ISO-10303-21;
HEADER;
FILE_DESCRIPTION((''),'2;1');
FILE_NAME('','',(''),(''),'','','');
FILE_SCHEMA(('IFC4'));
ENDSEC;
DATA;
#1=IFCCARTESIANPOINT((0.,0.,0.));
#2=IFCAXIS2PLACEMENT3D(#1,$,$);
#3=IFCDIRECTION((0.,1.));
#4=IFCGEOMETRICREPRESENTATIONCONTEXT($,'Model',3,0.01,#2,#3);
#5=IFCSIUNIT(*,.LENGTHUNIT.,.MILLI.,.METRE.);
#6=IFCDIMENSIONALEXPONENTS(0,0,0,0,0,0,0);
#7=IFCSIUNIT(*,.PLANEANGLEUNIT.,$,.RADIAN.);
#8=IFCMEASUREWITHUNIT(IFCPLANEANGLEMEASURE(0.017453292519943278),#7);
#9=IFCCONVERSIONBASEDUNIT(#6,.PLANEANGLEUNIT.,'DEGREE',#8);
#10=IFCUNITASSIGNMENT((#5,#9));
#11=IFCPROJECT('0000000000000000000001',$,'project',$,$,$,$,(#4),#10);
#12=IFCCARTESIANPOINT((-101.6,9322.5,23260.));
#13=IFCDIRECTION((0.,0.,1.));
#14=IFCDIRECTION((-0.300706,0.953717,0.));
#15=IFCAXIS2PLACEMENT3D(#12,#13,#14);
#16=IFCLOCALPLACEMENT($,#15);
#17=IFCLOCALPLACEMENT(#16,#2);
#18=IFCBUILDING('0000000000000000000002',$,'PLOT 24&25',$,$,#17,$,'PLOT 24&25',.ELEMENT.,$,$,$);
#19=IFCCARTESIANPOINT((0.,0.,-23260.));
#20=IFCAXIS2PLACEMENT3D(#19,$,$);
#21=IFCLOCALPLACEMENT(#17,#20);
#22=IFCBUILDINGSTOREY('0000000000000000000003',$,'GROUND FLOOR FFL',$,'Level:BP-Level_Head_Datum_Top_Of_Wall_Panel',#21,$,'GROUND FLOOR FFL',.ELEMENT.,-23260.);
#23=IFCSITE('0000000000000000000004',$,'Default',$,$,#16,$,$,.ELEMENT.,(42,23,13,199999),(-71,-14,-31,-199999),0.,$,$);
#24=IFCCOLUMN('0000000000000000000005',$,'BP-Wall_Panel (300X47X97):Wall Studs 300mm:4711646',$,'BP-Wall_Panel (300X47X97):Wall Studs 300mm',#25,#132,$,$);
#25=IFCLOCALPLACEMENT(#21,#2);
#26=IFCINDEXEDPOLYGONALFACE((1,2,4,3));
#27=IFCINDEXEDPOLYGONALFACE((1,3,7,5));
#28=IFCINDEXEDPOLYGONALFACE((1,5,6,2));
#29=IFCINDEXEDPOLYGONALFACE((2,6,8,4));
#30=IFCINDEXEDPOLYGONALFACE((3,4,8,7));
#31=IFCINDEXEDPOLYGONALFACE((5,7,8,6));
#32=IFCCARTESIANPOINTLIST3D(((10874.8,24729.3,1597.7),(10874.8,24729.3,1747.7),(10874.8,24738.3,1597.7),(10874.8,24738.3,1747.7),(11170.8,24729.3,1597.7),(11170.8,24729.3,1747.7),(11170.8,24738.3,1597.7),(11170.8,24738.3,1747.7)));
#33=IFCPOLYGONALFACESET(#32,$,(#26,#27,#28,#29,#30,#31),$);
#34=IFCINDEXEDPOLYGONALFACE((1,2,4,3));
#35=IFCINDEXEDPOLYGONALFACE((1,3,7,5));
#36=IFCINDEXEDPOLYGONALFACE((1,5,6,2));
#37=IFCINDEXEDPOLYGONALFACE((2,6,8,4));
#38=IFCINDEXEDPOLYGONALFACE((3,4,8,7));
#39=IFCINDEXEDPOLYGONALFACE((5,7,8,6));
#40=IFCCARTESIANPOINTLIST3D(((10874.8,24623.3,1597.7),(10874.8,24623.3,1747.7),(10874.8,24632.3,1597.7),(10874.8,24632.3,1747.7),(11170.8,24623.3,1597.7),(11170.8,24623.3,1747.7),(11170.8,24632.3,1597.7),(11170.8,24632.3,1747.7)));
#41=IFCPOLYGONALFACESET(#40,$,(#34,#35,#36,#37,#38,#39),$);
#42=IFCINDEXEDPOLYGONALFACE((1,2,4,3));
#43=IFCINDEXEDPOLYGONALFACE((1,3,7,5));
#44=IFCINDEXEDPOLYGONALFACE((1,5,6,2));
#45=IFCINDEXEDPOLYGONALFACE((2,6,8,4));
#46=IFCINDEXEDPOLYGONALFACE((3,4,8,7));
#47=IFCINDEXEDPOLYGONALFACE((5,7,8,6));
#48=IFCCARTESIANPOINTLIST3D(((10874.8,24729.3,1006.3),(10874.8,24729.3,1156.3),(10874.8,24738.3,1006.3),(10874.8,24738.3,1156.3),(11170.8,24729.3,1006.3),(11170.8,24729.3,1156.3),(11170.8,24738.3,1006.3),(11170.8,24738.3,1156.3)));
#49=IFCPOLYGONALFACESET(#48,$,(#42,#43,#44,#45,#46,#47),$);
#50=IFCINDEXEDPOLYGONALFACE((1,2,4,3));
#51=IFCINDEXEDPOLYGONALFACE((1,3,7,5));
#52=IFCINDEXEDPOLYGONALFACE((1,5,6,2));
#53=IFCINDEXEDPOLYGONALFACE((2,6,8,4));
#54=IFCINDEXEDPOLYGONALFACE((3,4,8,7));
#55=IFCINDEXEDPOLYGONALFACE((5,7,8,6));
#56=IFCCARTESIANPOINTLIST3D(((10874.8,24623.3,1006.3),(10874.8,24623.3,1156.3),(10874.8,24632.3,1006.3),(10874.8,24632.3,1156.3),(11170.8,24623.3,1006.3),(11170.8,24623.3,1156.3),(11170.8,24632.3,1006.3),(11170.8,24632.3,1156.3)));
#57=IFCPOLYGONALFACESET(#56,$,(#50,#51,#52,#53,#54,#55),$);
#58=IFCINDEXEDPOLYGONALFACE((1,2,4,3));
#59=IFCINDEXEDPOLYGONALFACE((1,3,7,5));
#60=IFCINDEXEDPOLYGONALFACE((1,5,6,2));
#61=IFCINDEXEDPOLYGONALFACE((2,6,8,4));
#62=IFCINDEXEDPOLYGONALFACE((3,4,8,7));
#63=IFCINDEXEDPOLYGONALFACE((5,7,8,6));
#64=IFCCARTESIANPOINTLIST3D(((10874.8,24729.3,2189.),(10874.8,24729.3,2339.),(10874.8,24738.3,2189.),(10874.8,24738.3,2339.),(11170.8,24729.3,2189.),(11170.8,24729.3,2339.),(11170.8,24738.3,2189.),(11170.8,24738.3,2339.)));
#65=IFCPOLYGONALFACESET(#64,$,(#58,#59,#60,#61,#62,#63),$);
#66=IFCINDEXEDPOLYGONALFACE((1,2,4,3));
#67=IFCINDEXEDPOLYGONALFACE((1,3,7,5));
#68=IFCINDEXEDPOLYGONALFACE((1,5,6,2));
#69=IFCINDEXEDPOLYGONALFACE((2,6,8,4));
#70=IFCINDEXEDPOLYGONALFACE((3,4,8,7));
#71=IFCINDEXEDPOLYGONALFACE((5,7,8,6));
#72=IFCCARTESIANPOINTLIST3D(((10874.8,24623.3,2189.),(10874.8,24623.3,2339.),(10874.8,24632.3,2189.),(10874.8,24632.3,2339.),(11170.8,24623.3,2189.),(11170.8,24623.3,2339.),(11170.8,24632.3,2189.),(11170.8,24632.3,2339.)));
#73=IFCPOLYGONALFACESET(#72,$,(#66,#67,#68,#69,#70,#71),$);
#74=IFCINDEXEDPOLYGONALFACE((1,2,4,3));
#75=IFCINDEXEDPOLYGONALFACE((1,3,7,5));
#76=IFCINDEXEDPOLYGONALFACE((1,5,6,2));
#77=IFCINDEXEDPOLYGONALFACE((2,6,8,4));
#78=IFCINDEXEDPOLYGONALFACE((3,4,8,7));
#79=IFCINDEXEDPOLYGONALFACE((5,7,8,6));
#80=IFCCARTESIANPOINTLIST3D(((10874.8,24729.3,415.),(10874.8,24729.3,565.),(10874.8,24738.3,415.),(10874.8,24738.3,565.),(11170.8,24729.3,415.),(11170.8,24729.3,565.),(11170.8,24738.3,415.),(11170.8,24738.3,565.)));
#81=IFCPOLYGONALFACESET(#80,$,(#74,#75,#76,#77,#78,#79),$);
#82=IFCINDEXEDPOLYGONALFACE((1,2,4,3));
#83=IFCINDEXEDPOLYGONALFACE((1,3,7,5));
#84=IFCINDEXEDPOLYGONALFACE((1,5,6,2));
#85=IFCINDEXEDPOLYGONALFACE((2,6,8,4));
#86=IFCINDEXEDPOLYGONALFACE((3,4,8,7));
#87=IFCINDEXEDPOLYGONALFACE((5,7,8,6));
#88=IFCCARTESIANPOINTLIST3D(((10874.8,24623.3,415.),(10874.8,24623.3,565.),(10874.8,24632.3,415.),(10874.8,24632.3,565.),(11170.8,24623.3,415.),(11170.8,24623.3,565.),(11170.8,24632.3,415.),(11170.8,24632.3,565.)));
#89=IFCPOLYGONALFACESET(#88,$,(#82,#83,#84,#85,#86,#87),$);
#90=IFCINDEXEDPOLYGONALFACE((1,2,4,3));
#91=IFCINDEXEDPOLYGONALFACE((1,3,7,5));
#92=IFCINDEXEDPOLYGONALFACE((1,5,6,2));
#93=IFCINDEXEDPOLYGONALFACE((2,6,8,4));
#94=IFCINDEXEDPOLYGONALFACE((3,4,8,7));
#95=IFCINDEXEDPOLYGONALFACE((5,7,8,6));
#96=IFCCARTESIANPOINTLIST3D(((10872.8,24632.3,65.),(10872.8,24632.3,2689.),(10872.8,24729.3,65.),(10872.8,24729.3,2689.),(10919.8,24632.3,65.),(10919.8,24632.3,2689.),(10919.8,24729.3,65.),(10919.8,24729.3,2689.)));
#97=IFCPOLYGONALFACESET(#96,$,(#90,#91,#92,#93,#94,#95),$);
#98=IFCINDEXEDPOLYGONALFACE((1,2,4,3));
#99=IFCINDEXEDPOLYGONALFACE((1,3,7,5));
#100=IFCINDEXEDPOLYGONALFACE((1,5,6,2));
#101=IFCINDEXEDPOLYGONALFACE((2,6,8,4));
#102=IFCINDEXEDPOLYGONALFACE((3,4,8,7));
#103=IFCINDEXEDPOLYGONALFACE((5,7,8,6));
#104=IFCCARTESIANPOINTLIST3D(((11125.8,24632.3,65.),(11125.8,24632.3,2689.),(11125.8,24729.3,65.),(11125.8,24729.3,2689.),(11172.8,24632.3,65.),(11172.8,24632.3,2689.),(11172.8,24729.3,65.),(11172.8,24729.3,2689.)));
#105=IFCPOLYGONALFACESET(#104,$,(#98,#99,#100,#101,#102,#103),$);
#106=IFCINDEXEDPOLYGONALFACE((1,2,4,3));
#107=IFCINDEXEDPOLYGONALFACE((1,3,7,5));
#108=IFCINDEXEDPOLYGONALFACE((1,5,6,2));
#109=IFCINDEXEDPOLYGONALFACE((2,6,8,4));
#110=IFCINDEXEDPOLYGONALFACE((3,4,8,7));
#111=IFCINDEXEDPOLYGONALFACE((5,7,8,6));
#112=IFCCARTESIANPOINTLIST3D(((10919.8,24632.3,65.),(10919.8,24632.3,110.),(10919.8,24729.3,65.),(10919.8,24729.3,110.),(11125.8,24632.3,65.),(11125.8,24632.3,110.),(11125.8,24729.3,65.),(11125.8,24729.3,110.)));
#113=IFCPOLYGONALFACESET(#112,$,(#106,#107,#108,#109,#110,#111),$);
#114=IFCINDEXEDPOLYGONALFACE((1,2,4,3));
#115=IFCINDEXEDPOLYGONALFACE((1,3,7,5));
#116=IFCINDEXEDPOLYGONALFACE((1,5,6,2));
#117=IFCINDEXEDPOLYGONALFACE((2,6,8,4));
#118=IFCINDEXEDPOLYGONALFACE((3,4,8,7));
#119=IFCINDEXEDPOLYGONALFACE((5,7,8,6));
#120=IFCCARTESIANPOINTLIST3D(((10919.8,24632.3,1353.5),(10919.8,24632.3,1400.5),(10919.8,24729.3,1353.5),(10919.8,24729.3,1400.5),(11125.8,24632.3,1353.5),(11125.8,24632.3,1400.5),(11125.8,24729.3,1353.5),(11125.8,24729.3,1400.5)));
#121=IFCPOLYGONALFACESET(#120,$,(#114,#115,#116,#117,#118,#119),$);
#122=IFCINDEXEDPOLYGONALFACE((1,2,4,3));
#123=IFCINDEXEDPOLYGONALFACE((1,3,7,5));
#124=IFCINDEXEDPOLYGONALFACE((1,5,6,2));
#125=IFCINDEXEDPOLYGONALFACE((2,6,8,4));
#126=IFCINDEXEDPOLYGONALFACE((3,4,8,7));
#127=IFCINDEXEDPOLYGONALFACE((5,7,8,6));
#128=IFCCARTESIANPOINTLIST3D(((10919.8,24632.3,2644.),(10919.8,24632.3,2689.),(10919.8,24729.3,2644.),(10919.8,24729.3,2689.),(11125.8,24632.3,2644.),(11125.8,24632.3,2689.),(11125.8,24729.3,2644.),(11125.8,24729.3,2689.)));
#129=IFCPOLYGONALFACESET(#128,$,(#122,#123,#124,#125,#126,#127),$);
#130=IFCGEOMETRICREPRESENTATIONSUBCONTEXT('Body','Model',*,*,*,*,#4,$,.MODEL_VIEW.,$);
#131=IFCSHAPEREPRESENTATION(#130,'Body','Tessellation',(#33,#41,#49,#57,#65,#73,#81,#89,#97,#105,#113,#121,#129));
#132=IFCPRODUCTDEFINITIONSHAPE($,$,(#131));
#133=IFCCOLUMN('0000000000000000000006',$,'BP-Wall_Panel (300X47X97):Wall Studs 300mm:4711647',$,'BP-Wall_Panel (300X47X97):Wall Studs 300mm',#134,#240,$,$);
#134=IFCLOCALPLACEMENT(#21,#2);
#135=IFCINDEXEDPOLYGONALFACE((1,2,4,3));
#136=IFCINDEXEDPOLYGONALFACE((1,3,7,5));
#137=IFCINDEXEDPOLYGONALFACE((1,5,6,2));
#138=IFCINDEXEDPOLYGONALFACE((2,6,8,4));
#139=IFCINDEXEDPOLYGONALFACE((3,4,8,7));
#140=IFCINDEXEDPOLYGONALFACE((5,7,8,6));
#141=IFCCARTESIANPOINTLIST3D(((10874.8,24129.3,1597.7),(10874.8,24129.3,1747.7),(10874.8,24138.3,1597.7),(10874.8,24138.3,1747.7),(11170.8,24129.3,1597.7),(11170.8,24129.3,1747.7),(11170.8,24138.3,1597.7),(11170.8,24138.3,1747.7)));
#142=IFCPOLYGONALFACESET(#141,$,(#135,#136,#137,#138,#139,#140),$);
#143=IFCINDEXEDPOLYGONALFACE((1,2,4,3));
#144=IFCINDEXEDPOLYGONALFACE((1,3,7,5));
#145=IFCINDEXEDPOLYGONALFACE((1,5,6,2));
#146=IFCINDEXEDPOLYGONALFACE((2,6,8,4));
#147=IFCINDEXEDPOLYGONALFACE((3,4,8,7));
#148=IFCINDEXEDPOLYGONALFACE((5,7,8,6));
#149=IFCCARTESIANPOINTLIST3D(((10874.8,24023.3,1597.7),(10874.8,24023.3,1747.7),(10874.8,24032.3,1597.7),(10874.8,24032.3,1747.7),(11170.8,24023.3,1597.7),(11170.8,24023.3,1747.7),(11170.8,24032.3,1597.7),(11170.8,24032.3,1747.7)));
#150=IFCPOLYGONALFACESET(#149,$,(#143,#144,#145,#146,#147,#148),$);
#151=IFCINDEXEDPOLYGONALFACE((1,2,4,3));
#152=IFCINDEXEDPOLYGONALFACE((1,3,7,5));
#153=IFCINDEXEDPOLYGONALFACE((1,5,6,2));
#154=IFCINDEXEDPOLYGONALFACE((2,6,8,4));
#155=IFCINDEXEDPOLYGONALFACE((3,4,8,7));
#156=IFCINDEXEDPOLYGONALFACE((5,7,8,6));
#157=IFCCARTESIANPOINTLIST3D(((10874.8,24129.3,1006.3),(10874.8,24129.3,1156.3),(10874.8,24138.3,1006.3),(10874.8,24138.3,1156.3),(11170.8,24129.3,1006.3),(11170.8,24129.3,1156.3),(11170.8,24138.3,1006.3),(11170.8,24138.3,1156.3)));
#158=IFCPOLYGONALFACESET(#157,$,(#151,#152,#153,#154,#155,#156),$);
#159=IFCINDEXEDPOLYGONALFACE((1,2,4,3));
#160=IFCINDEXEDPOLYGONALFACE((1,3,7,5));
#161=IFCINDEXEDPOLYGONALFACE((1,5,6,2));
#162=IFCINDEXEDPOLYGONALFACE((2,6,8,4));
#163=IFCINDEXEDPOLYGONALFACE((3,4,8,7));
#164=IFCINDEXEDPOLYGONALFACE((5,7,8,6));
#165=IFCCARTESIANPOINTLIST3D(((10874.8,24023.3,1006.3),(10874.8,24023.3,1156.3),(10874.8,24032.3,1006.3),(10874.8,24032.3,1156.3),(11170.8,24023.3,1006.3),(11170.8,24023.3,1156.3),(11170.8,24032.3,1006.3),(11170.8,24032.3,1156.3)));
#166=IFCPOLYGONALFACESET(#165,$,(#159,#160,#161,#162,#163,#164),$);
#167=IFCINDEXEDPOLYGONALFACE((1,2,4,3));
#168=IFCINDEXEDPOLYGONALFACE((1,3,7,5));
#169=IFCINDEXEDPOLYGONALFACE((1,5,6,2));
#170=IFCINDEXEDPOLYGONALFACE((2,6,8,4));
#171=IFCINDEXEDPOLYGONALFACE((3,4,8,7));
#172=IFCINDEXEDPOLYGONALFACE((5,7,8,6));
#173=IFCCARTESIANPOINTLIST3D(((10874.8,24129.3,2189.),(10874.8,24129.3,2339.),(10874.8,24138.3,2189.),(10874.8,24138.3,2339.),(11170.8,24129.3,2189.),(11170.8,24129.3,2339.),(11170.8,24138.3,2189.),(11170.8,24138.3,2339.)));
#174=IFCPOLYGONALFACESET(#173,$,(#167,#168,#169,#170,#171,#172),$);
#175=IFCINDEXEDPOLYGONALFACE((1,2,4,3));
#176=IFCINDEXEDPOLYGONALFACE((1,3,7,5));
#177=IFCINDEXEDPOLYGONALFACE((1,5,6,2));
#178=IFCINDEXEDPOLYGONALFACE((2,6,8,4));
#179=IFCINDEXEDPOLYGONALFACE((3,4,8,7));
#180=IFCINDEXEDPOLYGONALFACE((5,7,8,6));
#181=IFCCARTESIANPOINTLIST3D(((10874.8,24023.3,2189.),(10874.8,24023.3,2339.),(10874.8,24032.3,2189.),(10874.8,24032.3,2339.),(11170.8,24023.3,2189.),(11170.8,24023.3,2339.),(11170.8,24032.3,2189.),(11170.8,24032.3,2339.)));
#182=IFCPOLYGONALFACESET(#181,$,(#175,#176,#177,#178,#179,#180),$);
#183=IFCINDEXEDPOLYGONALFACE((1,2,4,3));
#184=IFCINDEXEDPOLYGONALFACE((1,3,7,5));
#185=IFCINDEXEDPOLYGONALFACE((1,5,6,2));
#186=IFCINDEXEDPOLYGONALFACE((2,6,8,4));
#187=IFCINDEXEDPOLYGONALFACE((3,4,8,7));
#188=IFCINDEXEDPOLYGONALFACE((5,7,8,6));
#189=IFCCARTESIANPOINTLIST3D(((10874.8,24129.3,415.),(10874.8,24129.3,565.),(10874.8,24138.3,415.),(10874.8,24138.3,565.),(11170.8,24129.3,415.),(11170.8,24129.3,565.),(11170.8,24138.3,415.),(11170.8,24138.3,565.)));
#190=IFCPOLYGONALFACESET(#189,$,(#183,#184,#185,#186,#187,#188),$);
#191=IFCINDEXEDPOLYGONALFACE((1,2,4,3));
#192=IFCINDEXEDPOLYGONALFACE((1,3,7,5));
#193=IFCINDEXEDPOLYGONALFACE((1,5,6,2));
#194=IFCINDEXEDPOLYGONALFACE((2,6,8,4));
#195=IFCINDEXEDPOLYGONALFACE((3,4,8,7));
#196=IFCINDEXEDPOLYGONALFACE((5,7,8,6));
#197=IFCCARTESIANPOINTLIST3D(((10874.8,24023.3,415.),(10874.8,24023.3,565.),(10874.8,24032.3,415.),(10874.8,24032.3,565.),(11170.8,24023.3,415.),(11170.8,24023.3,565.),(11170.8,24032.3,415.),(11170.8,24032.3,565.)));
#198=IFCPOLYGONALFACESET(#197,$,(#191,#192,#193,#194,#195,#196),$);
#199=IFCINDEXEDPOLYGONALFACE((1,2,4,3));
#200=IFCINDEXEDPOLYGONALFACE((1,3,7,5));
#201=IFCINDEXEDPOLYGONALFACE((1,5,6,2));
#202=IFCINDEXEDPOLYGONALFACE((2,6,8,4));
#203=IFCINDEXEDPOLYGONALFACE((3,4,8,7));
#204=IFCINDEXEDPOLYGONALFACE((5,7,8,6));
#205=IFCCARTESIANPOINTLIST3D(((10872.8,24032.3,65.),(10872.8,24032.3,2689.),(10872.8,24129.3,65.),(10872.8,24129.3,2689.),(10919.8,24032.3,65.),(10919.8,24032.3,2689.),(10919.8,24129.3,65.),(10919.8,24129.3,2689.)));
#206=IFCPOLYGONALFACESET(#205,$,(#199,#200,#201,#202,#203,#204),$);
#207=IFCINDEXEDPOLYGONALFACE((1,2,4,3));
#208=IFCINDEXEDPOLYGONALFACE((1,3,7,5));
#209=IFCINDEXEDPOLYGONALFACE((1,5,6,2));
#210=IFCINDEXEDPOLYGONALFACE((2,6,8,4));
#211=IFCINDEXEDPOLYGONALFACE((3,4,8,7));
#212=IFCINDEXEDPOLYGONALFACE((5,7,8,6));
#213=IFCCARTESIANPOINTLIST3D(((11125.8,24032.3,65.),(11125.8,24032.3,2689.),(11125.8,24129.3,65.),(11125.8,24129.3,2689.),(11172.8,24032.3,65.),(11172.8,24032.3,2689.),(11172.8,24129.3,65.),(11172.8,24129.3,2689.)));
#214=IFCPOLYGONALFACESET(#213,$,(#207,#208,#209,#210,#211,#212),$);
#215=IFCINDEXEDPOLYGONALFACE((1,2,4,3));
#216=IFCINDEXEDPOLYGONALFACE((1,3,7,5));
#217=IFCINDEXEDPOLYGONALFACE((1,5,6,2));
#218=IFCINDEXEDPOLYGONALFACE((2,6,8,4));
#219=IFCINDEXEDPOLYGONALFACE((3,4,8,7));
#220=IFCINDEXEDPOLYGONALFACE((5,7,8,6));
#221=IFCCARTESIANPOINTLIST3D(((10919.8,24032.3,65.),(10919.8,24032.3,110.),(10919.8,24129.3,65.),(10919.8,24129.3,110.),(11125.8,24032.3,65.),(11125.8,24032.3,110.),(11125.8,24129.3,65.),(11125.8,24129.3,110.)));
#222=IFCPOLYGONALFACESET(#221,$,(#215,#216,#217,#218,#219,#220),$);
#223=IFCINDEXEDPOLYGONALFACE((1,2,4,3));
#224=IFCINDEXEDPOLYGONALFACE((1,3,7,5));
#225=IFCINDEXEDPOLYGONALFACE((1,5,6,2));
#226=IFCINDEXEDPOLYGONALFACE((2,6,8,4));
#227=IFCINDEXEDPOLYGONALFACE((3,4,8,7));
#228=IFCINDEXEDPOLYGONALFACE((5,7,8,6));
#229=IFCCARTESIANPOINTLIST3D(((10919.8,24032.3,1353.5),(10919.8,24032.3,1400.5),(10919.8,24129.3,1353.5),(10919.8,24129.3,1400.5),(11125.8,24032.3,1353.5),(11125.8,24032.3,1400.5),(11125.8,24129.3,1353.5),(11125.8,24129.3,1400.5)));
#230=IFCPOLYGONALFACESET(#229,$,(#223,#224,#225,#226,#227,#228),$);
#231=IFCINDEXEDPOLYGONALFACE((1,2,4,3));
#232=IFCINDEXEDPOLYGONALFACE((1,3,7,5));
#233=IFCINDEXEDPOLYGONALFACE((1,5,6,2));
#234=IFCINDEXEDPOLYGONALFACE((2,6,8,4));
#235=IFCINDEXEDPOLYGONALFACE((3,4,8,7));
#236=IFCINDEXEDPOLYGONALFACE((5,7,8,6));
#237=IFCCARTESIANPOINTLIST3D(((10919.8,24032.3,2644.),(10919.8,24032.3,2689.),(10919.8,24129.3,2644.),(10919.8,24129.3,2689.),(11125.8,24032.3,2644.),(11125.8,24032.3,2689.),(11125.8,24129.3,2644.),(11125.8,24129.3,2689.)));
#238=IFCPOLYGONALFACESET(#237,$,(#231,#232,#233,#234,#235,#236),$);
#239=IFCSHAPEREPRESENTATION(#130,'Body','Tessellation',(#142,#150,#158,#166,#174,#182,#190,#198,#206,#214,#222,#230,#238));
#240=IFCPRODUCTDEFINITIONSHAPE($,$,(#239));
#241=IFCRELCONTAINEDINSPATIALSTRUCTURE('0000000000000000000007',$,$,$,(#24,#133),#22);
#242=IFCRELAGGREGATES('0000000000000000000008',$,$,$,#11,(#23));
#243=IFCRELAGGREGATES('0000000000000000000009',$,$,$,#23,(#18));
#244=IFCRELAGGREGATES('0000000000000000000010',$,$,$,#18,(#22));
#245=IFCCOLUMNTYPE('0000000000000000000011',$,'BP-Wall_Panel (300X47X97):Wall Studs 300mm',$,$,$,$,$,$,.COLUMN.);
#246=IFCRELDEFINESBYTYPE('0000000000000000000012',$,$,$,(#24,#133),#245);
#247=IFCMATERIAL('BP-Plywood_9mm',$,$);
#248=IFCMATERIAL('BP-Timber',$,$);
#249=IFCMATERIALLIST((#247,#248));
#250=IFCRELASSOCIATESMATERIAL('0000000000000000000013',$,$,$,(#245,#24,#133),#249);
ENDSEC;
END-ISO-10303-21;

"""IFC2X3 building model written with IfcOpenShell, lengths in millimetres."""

from ifc_helpers import new_model, entity, si_unit, converted_unit, direction, frame, frame_2d, origin, origin_2d_with_axis, place, context, subcontext, project, spatial, rectangle, extrude, source, transform, mapped, material, material_list, type_object, type_shapes, element, save


model = new_model("IFC2X3")

# Units and contexts
model_context = context("Model", 3, precision=0.01, world=origin(), true_north=direction((0.0, 1.0)))
body_context = subcontext(model_context, "Body", "Model", "MODEL_VIEW")
ifc_project = project(units=[si_unit("LENGTHUNIT", "METRE", prefix="MILLI"), converted_unit("PLANEANGLEUNIT", "DEGREE", entity("IfcPlaneAngleMeasure", 0.017453292519943278), si_unit("PLANEANGLEUNIT", "RADIAN"), dimensions=[0, 0, 0, 0, 0, 0, 0])], contexts=[model_context])

# Site, building, storey
site_placement = place(None, frame((-101.6, 9322.5, 23260.0), z_axis=(0.0, 0.0, 1.0), x_axis=(-0.300706, 0.953717, 0.0)))
site = spatial("IfcSite", under=ifc_project, at=site_placement, Name="Default", CompositionType="ELEMENT", RefLatitude=(42, 23, 13, 199999), RefLongitude=(-71, -14, -31, -199999), RefElevation=0.0)
building_placement = place(site_placement, origin())
building = spatial("IfcBuilding", under=site, at=building_placement, Name="PLOT 24&25", LongName="PLOT 24&25", CompositionType="ELEMENT")
storey_placement = place(building_placement, frame((0.0, 0.0, -23260.0)))
storey = spatial("IfcBuildingStorey", under=building, at=storey_placement, Name="GROUND FLOOR FFL", ObjectType="Level:BP-Level_Head_Datum_Top_Of_Wall_Panel", LongName="GROUND FLOOR FFL", CompositionType="ELEMENT", Elevation=-23260.0)

# Columns
ifc_material_1 = material(Name="BP-Plywood_9mm")
ifc_material_2 = material(Name="BP-Timber")
ifc_material_list = material_list([ifc_material_1, ifc_material_2])
column_type_1 = type_object("IfcColumnType", Name="BP-Wall_Panel (300X47X97):Wall Studs 300mm", PredefinedType="COLUMN", material=ifc_material_list)
shared_shape_1 = source(origin(), body_context, "Body", "SweptSolid", [
    extrude(rectangle(XDim=9.0, YDim=296.0, at=origin_2d_with_axis()), frame((53.0, 0.0, -21662.3)), (0.0, 0.0, 1.0), 150.0),
    extrude(rectangle(XDim=296.0, YDim=9.0, at=origin_2d_with_axis()), frame((-53.0, 0.0, -21662.3), z_axis=(0.0, 0.0, 1.0), x_axis=(0.0, 1.0, 0.0)), (0.0, 0.0, 1.0), 150.0),
    extrude(rectangle(XDim=9.0, YDim=296.0, at=origin_2d_with_axis()), frame((53.0, 0.0, -22253.7)), (0.0, 0.0, 1.0), 150.0),
    extrude(rectangle(XDim=296.0, YDim=9.0, at=origin_2d_with_axis()), frame((-53.0, 0.0, -22253.7), z_axis=(0.0, 0.0, 1.0), x_axis=(0.0, 1.0, 0.0)), (0.0, 0.0, 1.0), 150.0),
    extrude(rectangle(XDim=9.0, YDim=296.0, at=origin_2d_with_axis()), frame((53.0, 0.0, -21071.0)), (0.0, 0.0, 1.0), 150.0),
    extrude(rectangle(XDim=296.0, YDim=9.0, at=origin_2d_with_axis()), frame((-53.0, 0.0, -21071.0), z_axis=(0.0, 0.0, 1.0), x_axis=(0.0, 1.0, 0.0)), (0.0, 0.0, 1.0), 150.0),
    extrude(rectangle(XDim=9.0, YDim=296.0, at=origin_2d_with_axis()), frame((53.0, 0.0, -22845.0)), (0.0, 0.0, 1.0), 150.0),
    extrude(rectangle(XDim=296.0, YDim=9.0, at=origin_2d_with_axis()), frame((-53.0, 0.0, -22845.0), z_axis=(0.0, 0.0, 1.0), x_axis=(0.0, 1.0, 0.0)), (0.0, 0.0, 1.0), 150.0),
    extrude(rectangle(XDim=47.0, YDim=97.0, at=origin_2d_with_axis()), frame((0.0, 126.5, -23195.0), z_axis=(0.0, 0.0, 1.0), x_axis=(0.0, 1.0, 0.0)), (0.0, 0.0, 1.0), 2624.0),
    extrude(rectangle(XDim=47.0, YDim=97.0, at=frame_2d((0.0, 0.0), x_axis=(1.0, 0.0))), frame((0.0, -126.5, -23195.0), z_axis=(0.0, 0.0, 1.0), x_axis=(0.0, 1.0, 0.0)), (0.0, 0.0, 1.0), 2624.0),
    extrude(rectangle(XDim=97.0, YDim=206.0, at=origin_2d_with_axis()), frame((0.0, 0.0, -23195.0)), (0.0, 0.0, 1.0), 45.0),
    extrude(rectangle(XDim=97.0, YDim=206.0, at=origin_2d_with_axis()), frame((0.0, 0.0, -21906.5)), (0.0, 0.0, 1.0), 47.0),
    extrude(rectangle(XDim=97.0, YDim=206.0, at=origin_2d_with_axis()), frame((0.0, 0.0, -20616.0)), (0.0, 0.0, 1.0), 45.0),
])
type_shapes(column_type_1, [shared_shape_1])
for number, where, z_axis, x_axis, name in (
    (1, (11022.8, 24680.8, 23260.0), (0.0, 0.0, 1.0), (0.0, 1.0, 0.0), "BP-Wall_Panel (300X47X97):Wall Studs 300mm:4711646"),
    (2, (11022.8, 24080.8, 23260.0), (0.0, 0.0, 1.0), (0.0, 1.0, 0.0), "BP-Wall_Panel (300X47X97):Wall Studs 300mm:4711647"),
):
    element("IfcColumn", number, at=place(storey_placement, frame(where, z_axis=z_axis, x_axis=x_axis)), inside=storey, type_object=column_type_1, material=ifc_material_list, Name=name, ObjectType="BP-Wall_Panel (300X47X97):Wall Studs 300mm", context=body_context, shape_type="MappedRepresentation", body=[
        mapped(shared_shape_1, transform((0.0, 0.0, 0.0), scale=1.0)),
    ])

save(model, "model.ifc")
